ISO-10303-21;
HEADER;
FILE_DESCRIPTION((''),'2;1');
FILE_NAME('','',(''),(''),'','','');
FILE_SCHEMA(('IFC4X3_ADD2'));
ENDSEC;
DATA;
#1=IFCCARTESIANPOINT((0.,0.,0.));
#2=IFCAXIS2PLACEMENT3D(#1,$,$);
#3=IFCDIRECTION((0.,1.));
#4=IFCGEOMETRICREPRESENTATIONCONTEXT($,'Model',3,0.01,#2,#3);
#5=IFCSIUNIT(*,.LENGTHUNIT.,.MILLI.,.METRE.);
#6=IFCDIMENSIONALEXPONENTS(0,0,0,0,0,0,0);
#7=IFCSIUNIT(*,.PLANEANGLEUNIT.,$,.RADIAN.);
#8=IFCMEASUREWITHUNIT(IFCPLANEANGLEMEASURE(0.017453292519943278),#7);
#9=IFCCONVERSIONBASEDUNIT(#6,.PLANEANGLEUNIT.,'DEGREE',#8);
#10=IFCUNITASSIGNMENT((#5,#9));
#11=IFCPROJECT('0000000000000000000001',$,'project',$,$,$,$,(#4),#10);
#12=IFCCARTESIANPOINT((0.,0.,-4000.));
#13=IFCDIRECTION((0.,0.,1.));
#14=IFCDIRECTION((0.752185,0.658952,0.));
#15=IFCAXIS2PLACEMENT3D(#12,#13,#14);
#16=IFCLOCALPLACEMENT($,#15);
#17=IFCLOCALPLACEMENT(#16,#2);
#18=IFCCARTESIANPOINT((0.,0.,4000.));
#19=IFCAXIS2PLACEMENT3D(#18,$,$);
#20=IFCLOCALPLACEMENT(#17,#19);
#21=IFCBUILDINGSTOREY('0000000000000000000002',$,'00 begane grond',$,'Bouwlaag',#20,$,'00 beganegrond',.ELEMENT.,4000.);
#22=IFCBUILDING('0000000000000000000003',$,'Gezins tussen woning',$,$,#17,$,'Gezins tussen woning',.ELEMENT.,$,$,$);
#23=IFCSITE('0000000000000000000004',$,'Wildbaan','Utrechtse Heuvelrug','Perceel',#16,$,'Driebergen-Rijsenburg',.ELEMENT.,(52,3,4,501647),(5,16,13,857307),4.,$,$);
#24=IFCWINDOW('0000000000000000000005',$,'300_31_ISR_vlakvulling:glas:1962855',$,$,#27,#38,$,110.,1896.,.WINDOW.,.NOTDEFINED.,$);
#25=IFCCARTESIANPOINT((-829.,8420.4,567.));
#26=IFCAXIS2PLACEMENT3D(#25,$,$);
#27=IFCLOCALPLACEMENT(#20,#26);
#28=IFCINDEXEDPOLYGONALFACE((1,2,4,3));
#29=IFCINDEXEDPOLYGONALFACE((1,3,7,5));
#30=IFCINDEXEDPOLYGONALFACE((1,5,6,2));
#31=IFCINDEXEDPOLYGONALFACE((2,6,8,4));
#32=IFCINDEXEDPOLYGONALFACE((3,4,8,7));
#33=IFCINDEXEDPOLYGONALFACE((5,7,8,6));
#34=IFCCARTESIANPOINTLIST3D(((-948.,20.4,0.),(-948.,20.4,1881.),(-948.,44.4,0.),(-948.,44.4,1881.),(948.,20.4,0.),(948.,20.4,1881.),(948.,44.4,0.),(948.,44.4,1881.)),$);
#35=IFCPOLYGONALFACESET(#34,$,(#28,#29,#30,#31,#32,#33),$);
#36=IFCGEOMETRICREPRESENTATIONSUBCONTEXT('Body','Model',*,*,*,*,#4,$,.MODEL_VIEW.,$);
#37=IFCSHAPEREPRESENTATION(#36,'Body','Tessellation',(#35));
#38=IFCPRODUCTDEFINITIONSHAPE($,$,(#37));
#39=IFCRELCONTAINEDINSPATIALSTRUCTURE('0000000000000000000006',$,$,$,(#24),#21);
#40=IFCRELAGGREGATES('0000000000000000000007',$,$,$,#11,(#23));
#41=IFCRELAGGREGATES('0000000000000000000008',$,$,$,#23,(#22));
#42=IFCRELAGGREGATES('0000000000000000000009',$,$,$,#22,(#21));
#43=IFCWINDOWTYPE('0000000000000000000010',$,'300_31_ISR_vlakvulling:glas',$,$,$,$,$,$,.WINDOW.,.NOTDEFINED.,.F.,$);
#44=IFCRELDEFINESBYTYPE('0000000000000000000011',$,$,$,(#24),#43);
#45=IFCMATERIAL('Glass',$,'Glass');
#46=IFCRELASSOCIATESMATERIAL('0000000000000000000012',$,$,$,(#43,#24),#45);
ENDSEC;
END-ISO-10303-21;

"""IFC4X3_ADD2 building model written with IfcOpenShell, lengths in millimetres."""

from ifc_helpers import new_model, entity, si_unit, converted_unit, direction, frame, origin, origin_2d_with_axis, place, context, subcontext, project, spatial, rectangle, extrude, source, transform, mapped, material, type_object, type_shapes, element, save


model = new_model("IFC4X3_ADD2")

# Units and contexts
model_context = context("Model", 3, precision=0.01, world=origin(), true_north=direction((0.0, 1.0)))
body_context = subcontext(model_context, "Body", "Model", "MODEL_VIEW")
ifc_project = project(units=[si_unit("LENGTHUNIT", "METRE", prefix="MILLI"), converted_unit("PLANEANGLEUNIT", "DEGREE", entity("IfcPlaneAngleMeasure", 0.017453292519943278), si_unit("PLANEANGLEUNIT", "RADIAN"), dimensions=[0, 0, 0, 0, 0, 0, 0])], contexts=[model_context])

# Site, building, storey
site_placement = place(None, frame((0.0, 0.0, -4000.0), z_axis=(0.0, 0.0, 1.0), x_axis=(0.752185, 0.658952, 0.0)))
site = spatial("IfcSite", under=ifc_project, at=site_placement, Name="Wildbaan", Description="Utrechtse Heuvelrug", ObjectType="Perceel", LongName="Driebergen-Rijsenburg", CompositionType="ELEMENT", RefLatitude=(52, 3, 4, 501647), RefLongitude=(5, 16, 13, 857307), RefElevation=4.0)
building_placement = place(site_placement, origin())
building = spatial("IfcBuilding", under=site, at=building_placement, Name="Gezins tussen woning", LongName="Gezins tussen woning", CompositionType="ELEMENT")
storey_placement = place(building_placement, frame((0.0, 0.0, 4000.0)))
storey = spatial("IfcBuildingStorey", under=building, at=storey_placement, Name="00 begane grond", ObjectType="Bouwlaag", LongName="00 beganegrond", CompositionType="ELEMENT", Elevation=4000.0)

# Window
ifc_material_1 = material(Name="Glass", Category="Glass")
window_type_1 = type_object("IfcWindowType", Name="300_31_ISR_vlakvulling:glas", ParameterTakesPrecedence=False, PartitioningType="NOTDEFINED", PredefinedType="WINDOW", material=ifc_material_1)
shared_shape_1 = source(origin(), body_context, "Body", "SweptSolid", [
    extrude(rectangle(XDim=1896.0, YDim=24.0, at=origin_2d_with_axis()), frame((0.0, 32.4, 0.0)), (0.0, 0.0, 1.0), 1881.0),
])
type_shapes(window_type_1, [shared_shape_1])
window_1_placement = place(storey_placement, frame((-829.0, 8420.4, 567.0)))
element("IfcWindow", 1, at=window_1_placement, inside=storey, type_object=window_type_1, material=ifc_material_1, Name="300_31_ISR_vlakvulling:glas:1962855", OverallHeight=110.0, OverallWidth=1896.0, PartitioningType="NOTDEFINED", PredefinedType="WINDOW", context=body_context, shape_type="MappedRepresentation", body=[
    mapped(shared_shape_1, transform((0.0, 0.0, 0.0), scale=1.0)),
])

save(model, "model.ifc")
